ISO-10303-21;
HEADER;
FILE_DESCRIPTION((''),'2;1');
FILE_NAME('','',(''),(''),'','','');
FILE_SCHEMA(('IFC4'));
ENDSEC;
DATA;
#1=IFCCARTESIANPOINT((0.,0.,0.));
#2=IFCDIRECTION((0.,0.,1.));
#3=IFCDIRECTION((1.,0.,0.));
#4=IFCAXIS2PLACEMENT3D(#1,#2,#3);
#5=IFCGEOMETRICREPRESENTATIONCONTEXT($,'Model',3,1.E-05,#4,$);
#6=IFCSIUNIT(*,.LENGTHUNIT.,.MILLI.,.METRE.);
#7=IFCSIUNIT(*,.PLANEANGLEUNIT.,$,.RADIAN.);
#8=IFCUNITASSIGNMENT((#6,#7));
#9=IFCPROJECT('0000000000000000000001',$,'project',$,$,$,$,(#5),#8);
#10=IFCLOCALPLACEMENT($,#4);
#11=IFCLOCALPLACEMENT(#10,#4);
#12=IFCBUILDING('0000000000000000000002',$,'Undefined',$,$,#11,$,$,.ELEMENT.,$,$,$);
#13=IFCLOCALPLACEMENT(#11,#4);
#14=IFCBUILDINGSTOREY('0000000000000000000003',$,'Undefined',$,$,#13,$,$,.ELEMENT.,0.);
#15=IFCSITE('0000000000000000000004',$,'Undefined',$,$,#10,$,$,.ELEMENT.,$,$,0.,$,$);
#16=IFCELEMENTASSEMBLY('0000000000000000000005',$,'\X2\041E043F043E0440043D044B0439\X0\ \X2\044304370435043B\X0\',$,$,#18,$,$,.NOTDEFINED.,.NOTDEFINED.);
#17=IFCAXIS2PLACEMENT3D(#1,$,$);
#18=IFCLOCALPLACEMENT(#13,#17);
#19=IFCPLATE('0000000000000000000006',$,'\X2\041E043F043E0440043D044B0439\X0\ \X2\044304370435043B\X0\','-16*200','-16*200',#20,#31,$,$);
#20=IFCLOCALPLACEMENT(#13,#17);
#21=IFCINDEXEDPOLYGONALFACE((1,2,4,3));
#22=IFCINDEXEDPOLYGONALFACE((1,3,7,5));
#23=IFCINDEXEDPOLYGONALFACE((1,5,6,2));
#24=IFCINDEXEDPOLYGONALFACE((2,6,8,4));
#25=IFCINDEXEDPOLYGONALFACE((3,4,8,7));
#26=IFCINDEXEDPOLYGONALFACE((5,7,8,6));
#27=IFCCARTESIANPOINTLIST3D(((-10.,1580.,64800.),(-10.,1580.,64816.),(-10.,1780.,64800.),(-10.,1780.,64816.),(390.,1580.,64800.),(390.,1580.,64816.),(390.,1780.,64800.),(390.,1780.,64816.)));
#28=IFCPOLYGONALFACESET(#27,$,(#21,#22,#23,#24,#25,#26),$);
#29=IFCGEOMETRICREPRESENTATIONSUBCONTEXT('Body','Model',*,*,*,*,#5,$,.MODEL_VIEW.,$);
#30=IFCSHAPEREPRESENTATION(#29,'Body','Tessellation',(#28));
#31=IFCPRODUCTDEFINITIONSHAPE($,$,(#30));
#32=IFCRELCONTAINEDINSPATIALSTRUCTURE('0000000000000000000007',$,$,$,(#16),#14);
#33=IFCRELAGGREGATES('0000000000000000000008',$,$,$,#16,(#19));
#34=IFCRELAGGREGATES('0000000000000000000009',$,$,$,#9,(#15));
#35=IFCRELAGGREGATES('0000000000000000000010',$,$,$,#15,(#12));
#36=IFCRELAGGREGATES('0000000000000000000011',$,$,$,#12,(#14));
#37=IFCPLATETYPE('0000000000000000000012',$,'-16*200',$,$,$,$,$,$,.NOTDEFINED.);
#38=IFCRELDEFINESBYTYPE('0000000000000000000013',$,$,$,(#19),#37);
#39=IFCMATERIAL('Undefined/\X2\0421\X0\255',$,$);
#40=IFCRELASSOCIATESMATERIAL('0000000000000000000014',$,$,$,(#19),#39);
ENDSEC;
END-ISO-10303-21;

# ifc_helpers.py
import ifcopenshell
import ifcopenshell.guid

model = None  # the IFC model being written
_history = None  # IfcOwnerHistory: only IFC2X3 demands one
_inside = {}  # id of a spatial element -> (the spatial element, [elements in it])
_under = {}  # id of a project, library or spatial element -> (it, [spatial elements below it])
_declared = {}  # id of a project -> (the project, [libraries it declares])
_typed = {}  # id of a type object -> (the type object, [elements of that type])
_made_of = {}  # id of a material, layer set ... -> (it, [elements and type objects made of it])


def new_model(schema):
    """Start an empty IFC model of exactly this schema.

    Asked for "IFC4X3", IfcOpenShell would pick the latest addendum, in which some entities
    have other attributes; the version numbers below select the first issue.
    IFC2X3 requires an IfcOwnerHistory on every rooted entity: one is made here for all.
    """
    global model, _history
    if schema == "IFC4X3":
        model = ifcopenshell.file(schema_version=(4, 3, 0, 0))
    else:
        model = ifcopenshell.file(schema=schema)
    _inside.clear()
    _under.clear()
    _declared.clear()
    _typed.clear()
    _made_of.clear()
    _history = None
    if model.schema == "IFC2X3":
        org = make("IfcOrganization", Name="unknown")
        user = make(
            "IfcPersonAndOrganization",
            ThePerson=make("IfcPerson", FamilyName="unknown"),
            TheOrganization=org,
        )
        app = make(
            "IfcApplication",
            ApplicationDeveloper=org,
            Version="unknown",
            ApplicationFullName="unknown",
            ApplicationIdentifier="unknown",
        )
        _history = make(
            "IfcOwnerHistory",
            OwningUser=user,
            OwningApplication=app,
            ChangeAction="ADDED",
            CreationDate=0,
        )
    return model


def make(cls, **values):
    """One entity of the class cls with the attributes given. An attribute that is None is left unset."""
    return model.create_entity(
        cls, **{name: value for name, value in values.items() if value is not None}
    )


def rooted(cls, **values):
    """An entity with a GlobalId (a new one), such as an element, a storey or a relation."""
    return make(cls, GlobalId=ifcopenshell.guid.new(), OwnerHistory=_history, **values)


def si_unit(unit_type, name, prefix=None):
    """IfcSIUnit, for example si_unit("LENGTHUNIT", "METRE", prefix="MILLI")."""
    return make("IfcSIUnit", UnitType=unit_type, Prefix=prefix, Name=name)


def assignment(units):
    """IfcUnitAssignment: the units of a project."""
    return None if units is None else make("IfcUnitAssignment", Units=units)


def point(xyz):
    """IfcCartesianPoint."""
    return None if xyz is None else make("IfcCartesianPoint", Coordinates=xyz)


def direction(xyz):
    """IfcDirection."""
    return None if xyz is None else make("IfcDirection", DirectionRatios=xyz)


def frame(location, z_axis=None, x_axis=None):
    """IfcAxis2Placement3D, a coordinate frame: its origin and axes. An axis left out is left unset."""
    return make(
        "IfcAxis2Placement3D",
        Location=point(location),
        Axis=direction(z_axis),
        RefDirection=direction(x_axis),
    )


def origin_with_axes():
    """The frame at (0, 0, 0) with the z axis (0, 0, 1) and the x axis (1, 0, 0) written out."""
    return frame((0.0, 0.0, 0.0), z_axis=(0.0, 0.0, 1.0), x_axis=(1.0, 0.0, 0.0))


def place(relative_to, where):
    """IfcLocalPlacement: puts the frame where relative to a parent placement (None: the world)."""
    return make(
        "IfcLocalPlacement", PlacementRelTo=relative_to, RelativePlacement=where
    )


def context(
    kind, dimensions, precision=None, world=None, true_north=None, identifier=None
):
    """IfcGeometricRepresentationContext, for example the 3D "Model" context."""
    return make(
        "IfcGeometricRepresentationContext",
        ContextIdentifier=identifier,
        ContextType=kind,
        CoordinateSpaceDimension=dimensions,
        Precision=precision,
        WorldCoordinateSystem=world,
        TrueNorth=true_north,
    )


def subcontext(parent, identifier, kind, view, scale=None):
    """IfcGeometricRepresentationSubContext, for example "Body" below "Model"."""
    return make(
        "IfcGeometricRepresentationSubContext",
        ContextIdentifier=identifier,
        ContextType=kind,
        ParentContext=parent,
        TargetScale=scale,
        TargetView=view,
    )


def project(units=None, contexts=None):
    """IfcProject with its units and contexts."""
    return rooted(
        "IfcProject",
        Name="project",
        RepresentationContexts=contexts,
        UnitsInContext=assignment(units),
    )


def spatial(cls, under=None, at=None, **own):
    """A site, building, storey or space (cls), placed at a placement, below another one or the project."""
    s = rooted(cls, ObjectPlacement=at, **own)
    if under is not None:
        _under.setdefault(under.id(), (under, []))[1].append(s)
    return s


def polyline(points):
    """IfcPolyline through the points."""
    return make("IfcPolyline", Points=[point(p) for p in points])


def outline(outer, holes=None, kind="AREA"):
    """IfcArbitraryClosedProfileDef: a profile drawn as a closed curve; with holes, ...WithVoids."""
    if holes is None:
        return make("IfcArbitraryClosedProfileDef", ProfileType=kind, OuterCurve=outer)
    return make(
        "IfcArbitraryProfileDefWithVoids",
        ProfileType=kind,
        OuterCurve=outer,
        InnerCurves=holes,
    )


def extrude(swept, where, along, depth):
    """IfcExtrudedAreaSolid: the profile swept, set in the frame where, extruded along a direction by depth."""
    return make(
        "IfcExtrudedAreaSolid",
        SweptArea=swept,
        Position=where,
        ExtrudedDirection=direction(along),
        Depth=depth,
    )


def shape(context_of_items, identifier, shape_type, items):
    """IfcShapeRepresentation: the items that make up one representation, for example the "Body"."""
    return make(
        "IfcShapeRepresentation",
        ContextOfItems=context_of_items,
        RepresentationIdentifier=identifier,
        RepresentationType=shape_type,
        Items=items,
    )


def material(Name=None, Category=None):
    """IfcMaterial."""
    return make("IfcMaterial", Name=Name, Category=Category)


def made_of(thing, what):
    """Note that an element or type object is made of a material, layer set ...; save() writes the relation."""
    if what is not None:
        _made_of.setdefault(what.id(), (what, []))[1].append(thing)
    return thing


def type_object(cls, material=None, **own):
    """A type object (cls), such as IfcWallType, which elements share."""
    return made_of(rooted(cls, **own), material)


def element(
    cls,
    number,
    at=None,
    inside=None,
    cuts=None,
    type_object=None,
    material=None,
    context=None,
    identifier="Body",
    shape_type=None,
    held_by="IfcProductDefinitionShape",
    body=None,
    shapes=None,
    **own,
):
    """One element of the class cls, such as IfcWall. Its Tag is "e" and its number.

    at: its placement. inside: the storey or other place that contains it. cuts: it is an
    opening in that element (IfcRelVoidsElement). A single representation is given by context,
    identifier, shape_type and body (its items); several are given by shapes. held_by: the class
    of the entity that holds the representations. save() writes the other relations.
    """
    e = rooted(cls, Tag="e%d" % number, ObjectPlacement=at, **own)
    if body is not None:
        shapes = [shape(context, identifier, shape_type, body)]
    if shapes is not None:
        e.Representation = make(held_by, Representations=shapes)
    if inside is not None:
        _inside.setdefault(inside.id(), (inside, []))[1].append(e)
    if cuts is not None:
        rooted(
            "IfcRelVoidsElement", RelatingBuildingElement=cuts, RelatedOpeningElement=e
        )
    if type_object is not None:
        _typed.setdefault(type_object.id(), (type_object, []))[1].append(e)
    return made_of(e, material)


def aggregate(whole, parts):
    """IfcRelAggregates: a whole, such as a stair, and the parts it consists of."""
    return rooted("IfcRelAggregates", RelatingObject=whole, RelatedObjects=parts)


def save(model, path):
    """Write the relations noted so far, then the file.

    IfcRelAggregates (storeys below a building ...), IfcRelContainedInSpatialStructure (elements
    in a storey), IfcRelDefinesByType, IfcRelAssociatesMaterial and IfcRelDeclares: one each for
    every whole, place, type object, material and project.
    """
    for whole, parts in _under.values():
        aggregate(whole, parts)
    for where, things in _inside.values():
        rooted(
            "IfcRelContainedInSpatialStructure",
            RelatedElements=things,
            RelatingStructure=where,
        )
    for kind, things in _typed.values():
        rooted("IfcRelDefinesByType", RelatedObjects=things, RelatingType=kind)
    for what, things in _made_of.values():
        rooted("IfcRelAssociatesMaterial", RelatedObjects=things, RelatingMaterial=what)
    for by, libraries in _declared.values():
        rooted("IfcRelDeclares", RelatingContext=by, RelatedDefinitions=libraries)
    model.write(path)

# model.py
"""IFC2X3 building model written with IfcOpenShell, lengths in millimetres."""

from ifc_helpers import new_model, si_unit, frame, origin_with_axes, place, context, subcontext, project, spatial, polyline, outline, extrude, material, type_object, element, aggregate, save


model = new_model("IFC2X3")

# Units and contexts
model_context = context("Model", 3, precision=1e-05, world=origin_with_axes())
body_context = subcontext(model_context, "Body", "Model", "MODEL_VIEW")
ifc_project = project(units=[si_unit("LENGTHUNIT", "METRE", prefix="MILLI"), si_unit("PLANEANGLEUNIT", "RADIAN")], contexts=[model_context])

# Site, building, storey
site_placement = place(None, origin_with_axes())
site = spatial("IfcSite", under=ifc_project, at=site_placement, Name="Undefined", CompositionType="ELEMENT", RefElevation=0.0)
building_placement = place(site_placement, origin_with_axes())
building = spatial("IfcBuilding", under=site, at=building_placement, Name="Undefined", CompositionType="ELEMENT")
storey_placement = place(building_placement, origin_with_axes())
storey = spatial("IfcBuildingStorey", under=building, at=storey_placement, Name="Undefined", CompositionType="ELEMENT", Elevation=0.0)

# Shared definitions
ifc_material_1 = material(Name="Undefined/С255")

# Element assembly
assembly_1_placement = place(storey_placement, origin_with_axes())
assembly_1 = element("IfcElementAssembly", 1, at=assembly_1_placement, inside=storey, Name="Опорный узел", AssemblyPlace="NOTDEFINED", PredefinedType="NOTDEFINED")

# Plate
plate_type_1 = type_object("IfcPlateType", Name="-16*200", PredefinedType="NOTDEFINED")
plate_1_placement = place(assembly_1_placement, frame((390.0, 1780.0, 64808.0), z_axis=(0.0, 0.0, 1.0), x_axis=(-1.0, 0.0, 0.0)))
plate_1 = element("IfcPlate", 2, at=plate_1_placement, type_object=plate_type_1, material=ifc_material_1, Name="Опорный узел", Description="-16*200", ObjectType="-16*200", context=body_context, shape_type="SweptSolid", body=[
    extrude(outline(polyline([(0.0, 0.0), (400.0, 0.0), (400.0, 200.0), (0.0, 200.0), (0.0, 0.0)])), frame((0.0, 0.0, -8.0), z_axis=(0.0, 0.0, 1.0), x_axis=(1.0, 0.0, 0.0)), (0.0, 0.0, 1.0), 16.0),
])

aggregate(assembly_1, [plate_1])

save(model, "model.ifc")
